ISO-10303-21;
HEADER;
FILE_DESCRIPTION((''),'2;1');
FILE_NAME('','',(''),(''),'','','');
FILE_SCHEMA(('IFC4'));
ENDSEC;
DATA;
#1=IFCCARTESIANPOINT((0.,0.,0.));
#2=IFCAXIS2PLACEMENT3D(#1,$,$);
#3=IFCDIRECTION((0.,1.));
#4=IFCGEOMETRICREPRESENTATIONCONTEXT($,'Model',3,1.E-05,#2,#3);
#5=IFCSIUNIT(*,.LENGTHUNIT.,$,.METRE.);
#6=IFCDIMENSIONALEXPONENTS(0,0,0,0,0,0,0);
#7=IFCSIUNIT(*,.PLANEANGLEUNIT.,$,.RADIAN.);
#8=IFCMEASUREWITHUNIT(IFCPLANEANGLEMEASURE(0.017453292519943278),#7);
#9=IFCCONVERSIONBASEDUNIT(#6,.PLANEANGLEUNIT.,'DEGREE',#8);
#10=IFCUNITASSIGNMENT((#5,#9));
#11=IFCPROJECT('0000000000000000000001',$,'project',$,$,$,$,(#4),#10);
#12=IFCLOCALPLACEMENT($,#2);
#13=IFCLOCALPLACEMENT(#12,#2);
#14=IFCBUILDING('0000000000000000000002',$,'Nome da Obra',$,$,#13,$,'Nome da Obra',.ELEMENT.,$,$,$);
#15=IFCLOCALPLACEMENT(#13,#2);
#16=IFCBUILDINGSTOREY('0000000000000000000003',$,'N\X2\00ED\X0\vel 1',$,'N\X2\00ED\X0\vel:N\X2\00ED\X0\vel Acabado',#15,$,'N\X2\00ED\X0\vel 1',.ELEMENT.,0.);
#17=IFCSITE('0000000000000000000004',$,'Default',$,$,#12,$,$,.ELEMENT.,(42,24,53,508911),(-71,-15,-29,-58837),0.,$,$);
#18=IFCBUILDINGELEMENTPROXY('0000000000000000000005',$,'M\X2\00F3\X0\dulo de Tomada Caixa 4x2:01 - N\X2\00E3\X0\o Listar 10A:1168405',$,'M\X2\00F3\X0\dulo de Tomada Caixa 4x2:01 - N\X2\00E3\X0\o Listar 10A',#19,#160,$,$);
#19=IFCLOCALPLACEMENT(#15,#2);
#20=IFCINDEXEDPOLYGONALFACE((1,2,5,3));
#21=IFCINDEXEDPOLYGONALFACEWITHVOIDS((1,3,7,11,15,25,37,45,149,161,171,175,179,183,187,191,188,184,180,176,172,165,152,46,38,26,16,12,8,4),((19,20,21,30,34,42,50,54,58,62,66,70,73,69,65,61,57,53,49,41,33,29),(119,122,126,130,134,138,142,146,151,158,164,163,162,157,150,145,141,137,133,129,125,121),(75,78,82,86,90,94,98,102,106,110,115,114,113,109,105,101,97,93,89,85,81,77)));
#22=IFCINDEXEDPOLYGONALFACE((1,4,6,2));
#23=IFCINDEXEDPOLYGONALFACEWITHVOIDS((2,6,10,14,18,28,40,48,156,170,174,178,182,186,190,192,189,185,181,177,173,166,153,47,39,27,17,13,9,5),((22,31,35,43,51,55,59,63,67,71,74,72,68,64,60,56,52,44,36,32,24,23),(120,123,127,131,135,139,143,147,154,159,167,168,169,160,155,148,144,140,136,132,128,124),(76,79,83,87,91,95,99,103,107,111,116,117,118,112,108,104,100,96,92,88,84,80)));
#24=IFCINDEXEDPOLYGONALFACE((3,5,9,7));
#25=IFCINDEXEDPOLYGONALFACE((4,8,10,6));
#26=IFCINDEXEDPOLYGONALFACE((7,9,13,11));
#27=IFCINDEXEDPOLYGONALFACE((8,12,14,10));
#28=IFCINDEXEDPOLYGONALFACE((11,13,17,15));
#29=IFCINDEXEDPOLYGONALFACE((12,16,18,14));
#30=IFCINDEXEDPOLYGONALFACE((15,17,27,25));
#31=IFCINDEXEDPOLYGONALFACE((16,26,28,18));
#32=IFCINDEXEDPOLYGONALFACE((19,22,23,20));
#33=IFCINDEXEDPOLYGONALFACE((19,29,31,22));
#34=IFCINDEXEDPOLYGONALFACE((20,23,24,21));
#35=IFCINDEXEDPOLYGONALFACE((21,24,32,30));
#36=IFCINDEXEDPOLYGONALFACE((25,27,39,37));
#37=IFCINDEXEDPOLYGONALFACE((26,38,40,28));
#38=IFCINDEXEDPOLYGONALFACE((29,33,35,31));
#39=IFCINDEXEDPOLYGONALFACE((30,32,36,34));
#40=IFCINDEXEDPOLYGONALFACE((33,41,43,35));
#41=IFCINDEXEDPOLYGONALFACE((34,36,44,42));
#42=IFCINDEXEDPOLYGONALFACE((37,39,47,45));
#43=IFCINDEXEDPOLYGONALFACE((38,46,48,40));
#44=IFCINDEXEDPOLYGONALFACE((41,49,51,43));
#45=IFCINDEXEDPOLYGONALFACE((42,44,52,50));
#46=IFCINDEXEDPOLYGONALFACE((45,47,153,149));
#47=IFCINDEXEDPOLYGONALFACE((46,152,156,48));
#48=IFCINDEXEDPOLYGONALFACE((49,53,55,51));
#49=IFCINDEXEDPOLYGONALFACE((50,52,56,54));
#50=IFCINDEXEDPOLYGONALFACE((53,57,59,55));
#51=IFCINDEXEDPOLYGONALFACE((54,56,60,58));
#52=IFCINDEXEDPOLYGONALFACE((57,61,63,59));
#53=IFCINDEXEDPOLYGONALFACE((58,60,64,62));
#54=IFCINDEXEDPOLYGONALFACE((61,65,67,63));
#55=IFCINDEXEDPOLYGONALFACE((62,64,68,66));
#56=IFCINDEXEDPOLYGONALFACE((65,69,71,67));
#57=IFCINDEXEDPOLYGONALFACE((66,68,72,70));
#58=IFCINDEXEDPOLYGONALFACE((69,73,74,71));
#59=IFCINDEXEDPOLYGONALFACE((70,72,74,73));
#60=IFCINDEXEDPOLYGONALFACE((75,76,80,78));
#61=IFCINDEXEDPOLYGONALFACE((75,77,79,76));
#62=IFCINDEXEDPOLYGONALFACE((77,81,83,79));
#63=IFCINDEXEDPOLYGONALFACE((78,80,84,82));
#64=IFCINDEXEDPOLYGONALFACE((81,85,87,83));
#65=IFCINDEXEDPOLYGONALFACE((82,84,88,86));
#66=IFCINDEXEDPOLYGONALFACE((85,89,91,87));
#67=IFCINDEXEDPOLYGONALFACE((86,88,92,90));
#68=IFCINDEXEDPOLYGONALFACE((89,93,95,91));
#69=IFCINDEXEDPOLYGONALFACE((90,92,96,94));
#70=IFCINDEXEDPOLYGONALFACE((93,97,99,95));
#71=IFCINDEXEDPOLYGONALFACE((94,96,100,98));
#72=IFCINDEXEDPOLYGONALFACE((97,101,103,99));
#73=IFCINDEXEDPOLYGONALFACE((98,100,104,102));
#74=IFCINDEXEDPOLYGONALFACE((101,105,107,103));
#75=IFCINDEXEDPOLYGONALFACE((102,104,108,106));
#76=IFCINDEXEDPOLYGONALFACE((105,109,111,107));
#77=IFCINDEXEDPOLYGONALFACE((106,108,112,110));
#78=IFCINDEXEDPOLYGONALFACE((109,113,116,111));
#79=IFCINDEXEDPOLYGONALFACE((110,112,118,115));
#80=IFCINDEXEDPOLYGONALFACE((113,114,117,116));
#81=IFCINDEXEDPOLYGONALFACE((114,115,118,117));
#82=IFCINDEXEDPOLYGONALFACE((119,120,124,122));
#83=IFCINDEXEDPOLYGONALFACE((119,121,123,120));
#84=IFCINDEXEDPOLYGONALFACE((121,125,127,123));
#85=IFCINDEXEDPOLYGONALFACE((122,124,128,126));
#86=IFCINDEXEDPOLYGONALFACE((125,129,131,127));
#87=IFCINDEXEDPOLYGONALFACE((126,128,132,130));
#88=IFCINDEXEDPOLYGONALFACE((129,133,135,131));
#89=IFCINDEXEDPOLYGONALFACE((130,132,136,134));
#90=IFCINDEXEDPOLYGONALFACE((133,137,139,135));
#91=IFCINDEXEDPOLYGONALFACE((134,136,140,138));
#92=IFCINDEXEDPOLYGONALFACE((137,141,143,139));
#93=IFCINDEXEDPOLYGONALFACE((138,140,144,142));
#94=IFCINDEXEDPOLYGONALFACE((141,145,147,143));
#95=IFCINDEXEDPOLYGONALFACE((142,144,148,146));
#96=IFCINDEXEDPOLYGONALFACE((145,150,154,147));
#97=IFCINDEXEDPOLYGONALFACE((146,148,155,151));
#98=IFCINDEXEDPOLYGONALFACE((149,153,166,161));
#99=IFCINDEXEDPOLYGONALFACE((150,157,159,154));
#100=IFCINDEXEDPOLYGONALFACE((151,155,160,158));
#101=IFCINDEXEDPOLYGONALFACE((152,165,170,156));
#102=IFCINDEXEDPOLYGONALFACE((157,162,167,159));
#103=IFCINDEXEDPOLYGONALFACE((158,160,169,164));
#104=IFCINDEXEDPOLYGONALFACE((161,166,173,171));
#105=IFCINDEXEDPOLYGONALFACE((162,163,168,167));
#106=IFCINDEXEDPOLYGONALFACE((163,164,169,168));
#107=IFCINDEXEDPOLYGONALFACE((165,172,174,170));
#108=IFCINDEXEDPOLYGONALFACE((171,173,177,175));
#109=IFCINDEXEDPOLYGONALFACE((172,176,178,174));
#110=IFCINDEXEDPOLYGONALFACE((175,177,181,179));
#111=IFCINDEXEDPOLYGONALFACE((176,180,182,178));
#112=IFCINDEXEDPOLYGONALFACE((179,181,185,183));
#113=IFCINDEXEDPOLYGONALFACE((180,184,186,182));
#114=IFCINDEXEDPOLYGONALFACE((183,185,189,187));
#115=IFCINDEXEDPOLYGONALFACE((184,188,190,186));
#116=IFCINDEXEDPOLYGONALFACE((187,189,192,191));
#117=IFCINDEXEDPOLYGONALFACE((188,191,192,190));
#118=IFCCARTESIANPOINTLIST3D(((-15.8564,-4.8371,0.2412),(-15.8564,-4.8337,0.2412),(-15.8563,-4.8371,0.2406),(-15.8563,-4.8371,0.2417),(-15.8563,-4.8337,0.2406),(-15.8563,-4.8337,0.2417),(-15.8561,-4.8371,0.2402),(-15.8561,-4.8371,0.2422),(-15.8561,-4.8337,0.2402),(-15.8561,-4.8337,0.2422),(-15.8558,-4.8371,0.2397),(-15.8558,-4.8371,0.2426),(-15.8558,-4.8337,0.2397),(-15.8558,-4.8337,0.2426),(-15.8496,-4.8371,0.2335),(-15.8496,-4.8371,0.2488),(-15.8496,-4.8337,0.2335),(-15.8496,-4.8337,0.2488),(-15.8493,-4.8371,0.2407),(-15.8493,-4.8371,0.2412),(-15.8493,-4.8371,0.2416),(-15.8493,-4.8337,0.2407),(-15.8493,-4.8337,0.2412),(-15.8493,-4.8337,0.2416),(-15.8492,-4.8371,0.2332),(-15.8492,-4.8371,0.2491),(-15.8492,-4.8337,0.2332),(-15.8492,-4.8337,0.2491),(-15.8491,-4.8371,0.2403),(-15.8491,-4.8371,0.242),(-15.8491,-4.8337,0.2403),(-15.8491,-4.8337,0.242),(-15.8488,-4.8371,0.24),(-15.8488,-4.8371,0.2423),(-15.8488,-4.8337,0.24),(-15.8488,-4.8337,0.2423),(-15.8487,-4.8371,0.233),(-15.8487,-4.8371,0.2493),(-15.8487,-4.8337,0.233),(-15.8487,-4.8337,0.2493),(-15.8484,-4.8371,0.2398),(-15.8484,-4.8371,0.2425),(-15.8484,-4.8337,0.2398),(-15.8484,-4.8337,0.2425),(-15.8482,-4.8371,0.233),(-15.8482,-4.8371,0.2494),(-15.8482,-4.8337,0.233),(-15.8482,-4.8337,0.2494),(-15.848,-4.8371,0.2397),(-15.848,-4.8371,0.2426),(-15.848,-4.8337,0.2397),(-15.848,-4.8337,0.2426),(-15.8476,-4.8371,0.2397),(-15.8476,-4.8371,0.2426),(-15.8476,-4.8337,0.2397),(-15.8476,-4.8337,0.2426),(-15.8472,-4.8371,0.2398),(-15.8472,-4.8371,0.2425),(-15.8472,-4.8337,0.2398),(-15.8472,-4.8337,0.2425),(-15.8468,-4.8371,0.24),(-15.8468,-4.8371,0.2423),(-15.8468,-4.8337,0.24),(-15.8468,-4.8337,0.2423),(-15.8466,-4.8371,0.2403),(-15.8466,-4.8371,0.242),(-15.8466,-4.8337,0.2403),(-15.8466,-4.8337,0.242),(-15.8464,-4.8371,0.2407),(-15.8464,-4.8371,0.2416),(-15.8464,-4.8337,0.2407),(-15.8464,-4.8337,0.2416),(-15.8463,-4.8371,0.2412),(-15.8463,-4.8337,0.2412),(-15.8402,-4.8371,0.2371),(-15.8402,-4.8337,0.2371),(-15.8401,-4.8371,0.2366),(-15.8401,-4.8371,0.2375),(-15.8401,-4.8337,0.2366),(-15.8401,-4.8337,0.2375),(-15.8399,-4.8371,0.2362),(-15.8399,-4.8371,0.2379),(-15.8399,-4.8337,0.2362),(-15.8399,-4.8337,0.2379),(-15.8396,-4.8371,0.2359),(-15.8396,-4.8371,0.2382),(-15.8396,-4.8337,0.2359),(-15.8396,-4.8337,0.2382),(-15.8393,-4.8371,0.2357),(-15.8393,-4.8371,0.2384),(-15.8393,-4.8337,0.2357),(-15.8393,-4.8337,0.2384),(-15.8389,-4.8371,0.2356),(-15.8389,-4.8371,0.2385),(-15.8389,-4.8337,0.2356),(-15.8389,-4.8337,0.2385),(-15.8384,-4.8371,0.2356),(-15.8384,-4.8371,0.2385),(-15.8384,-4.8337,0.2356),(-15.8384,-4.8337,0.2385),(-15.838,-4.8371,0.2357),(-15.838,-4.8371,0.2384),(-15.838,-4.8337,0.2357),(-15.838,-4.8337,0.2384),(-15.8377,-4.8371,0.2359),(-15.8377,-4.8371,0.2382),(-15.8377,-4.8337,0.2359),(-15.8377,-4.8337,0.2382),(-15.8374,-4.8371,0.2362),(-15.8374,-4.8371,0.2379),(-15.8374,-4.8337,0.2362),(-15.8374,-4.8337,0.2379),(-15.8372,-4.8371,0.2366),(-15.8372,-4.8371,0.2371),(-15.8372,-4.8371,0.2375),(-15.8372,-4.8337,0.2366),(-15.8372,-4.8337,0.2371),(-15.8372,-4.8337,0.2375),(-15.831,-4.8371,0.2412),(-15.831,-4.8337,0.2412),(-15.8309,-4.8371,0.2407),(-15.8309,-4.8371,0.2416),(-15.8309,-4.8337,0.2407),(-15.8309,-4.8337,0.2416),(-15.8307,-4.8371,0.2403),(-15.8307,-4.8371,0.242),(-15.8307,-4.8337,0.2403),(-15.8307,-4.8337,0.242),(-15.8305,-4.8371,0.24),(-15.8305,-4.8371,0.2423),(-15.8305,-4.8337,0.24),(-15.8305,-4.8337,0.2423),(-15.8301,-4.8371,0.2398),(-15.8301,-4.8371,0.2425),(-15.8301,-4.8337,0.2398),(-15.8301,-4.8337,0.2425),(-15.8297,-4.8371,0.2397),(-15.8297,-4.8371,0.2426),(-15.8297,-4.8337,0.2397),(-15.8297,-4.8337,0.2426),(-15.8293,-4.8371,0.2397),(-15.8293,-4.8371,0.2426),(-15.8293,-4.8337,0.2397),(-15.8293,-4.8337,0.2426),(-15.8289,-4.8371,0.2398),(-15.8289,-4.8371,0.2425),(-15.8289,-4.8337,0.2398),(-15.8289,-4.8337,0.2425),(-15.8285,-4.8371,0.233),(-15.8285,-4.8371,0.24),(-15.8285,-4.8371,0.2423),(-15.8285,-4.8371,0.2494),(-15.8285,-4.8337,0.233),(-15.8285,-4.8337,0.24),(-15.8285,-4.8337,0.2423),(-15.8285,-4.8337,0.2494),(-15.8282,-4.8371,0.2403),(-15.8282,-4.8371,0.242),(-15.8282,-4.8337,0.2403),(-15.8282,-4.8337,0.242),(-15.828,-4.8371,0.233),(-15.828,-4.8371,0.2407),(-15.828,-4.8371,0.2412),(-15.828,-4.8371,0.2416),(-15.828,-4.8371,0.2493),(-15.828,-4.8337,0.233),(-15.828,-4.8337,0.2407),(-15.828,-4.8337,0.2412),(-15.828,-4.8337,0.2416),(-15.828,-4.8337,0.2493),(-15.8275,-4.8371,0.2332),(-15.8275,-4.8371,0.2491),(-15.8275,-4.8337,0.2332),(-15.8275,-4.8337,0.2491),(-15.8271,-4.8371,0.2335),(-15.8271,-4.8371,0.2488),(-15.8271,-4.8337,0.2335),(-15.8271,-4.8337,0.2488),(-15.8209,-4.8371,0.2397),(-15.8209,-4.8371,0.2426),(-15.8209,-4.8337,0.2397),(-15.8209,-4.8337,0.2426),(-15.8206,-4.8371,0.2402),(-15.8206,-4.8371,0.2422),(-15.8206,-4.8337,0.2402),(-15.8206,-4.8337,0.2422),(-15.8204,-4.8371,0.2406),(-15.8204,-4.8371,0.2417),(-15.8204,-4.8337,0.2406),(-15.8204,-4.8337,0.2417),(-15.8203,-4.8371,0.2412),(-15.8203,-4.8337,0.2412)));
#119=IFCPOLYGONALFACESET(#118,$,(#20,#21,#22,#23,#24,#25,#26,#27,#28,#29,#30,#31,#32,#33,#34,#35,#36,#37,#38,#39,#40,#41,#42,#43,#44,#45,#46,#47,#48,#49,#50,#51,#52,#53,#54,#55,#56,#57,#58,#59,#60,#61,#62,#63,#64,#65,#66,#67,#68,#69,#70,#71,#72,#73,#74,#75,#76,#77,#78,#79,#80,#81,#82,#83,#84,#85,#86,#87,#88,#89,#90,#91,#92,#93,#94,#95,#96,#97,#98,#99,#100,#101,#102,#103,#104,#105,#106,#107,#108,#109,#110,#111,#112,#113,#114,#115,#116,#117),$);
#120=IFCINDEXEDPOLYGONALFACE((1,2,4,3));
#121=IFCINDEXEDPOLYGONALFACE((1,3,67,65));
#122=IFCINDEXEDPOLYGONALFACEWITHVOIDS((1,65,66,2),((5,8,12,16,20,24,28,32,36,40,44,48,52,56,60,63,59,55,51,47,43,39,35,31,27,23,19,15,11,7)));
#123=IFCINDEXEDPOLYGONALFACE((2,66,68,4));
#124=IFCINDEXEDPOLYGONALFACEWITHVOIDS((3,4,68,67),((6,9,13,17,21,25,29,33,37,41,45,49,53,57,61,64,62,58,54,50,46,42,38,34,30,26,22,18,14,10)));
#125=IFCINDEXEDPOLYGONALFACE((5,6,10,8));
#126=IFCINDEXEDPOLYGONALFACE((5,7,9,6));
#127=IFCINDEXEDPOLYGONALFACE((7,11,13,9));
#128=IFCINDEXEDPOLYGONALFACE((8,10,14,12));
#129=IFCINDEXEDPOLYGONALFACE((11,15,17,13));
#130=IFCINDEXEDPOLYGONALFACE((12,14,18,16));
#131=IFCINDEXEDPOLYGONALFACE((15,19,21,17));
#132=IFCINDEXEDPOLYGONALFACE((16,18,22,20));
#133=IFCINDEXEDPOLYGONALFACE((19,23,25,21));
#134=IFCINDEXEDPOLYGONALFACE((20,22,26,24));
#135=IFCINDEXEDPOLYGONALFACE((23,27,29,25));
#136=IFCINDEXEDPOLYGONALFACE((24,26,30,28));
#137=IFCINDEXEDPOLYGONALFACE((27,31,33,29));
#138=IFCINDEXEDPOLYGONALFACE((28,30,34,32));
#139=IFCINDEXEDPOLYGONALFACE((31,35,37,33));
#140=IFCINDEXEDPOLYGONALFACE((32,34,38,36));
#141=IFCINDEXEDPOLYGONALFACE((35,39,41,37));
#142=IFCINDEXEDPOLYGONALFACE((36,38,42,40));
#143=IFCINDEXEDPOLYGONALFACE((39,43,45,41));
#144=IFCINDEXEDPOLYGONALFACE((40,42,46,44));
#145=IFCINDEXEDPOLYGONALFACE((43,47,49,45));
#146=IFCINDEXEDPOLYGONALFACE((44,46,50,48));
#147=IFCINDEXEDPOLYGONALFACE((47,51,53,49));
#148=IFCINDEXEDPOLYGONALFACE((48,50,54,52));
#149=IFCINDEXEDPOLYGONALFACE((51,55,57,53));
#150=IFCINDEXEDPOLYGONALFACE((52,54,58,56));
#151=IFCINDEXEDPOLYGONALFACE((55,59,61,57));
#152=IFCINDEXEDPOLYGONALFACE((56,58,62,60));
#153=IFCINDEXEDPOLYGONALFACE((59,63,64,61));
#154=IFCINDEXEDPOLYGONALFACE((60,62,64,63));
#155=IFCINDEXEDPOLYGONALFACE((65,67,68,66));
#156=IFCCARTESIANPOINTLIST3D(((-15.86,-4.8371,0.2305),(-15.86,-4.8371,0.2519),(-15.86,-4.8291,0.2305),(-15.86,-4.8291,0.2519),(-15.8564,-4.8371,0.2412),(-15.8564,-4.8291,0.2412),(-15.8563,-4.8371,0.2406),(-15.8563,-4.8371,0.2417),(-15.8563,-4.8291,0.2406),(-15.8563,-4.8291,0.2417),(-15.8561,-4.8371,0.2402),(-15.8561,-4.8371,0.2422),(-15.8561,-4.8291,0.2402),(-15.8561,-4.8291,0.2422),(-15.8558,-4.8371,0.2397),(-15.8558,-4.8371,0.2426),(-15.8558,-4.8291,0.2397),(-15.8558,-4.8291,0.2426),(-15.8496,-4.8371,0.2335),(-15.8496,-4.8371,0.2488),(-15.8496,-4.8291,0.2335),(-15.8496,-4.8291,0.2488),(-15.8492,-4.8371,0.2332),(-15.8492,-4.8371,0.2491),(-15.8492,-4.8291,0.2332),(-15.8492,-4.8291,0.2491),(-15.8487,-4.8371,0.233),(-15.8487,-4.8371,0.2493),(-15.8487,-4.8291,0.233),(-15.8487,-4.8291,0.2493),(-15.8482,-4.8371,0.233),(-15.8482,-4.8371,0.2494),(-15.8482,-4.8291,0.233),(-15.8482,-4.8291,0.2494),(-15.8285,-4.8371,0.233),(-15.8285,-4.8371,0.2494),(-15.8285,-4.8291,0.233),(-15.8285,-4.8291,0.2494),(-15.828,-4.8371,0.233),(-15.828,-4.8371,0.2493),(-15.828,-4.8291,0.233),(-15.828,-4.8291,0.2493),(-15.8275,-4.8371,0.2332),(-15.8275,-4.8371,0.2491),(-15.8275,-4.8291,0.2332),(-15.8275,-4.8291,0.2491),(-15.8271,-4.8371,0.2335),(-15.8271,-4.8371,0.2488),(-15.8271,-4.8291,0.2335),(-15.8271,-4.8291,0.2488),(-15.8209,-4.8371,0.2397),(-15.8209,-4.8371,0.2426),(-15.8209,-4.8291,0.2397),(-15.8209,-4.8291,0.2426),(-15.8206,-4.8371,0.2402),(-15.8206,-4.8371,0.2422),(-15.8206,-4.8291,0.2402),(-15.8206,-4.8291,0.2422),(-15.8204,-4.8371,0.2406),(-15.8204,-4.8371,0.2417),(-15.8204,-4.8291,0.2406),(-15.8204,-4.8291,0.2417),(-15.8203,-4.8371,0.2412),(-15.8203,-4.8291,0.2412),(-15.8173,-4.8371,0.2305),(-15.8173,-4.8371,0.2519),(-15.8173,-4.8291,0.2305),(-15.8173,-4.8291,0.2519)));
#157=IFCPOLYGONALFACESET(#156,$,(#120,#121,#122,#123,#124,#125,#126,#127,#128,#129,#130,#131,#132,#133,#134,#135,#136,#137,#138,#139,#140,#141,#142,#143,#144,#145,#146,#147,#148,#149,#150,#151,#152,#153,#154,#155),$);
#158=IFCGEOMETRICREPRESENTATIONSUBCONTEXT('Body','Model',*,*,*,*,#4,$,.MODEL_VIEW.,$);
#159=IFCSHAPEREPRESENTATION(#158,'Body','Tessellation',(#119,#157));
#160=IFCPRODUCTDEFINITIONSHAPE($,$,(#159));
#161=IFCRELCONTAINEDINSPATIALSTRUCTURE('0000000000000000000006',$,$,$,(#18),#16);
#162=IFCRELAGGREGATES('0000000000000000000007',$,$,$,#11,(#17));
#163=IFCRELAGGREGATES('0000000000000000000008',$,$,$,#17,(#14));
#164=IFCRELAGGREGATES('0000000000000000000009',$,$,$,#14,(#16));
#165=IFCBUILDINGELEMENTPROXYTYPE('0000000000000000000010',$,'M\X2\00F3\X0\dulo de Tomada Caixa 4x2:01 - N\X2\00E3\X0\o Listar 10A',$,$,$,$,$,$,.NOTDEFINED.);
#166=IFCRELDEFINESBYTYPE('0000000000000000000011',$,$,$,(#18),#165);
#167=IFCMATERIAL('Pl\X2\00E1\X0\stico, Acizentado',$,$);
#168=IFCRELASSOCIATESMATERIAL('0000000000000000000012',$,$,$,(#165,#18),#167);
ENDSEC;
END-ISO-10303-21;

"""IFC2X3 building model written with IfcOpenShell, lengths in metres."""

from ifc_helpers import new_model, entity, si_unit, converted_unit, direction, frame, frame_2d, origin, place, context, subcontext, project, spatial, polyline, circle_curve, parameter, trimmed, segment, composite_curve, outline, extrude, source, transform, mapped, material, type_object, type_shapes, element, save


model = new_model("IFC2X3")

# Units and contexts
model_context = context("Model", 3, precision=1e-05, world=origin(), true_north=direction((0.0, 1.0)))
body_context = subcontext(model_context, "Body", "Model", "MODEL_VIEW")
ifc_project = project(units=[si_unit("LENGTHUNIT", "METRE"), converted_unit("PLANEANGLEUNIT", "DEGREE", entity("IfcPlaneAngleMeasure", 0.017453292519943278), si_unit("PLANEANGLEUNIT", "RADIAN"), dimensions=[0, 0, 0, 0, 0, 0, 0])], contexts=[model_context])

# Site, building, storey
site_placement = place(None, origin())
site = spatial("IfcSite", under=ifc_project, at=site_placement, Name="Default", CompositionType="ELEMENT", RefLatitude=(42, 24, 53, 508911), RefLongitude=(-71, -15, -29, -58837), RefElevation=0.0)
building_placement = place(site_placement, origin())
building = spatial("IfcBuilding", under=site, at=building_placement, Name="Nome da Obra", LongName="Nome da Obra", CompositionType="ELEMENT")
storey_placement = place(building_placement, origin())
storey = spatial("IfcBuildingStorey", under=building, at=storey_placement, Name="Nível 1", ObjectType="Nível:Nível Acabado", LongName="Nível 1", CompositionType="ELEMENT", Elevation=0.0)

# Building element proxy
ifc_material_1 = material(Name="Plástico, Acizentado")
building_element_proxy_type_1 = type_object("IfcBuildingElementProxyType", Name="Módulo de Tomada Caixa 4x2:01 - Não Listar 10A", PredefinedType="NOTDEFINED", material=ifc_material_1)
shared_shape_1 = source(origin(), body_context, "Body", "SweptSolid", [
    extrude(outline(composite_curve([segment(polyline([(-0.0098, -0.0082), (0.0098, -0.0082)]), True, "CONTINUOUS"), segment(trimmed(circle_curve(frame_2d((0.0098, -0.0062), x_axis=(1.0, 0.0)), 0.002), [parameter(270.0)], [parameter(315.0)], True, "PARAMETER"), True, "CONTINUOUS"), segment(polyline([(0.0112, -0.0076), (0.0174, -0.0014)]), True, "CONTINUOUS"), segment(trimmed(circle_curve(frame_2d((0.016, 0.0), x_axis=(1.0, 0.0)), 0.002), [parameter(315.0)], [parameter(45.0)], True, "PARAMETER"), True, "CONTINUOUS"), segment(polyline([(0.0174, 0.0014), (0.0112, 0.0076)]), True, "CONTINUOUS"), segment(trimmed(circle_curve(frame_2d((0.0098, 0.0062), x_axis=(1.0, 0.0)), 0.002), [parameter(45.0)], [parameter(90.0)], True, "PARAMETER"), True, "CONTINUOUS"), segment(polyline([(0.0098, 0.0082), (-0.0098, 0.0082)]), True, "CONTINUOUS"), segment(trimmed(circle_curve(frame_2d((-0.0098, 0.0062), x_axis=(1.0, 0.0)), 0.002), [parameter(90.0)], [parameter(135.0)], True, "PARAMETER"), True, "CONTINUOUS"), segment(polyline([(-0.0112, 0.0076), (-0.0174, 0.0014)]), True, "CONTINUOUS"), segment(trimmed(circle_curve(frame_2d((-0.016, 0.0), x_axis=(1.0, 0.0)), 0.002), [parameter(135.0)], [parameter(225.0)], True, "PARAMETER"), True, "CONTINUOUS"), segment(polyline([(-0.0174, -0.0014), (-0.0112, -0.0076)]), True, "CONTINUOUS"), segment(trimmed(circle_curve(frame_2d((-0.0098, -0.0062), x_axis=(1.0, 0.0)), 0.002), [parameter(225.0)], [parameter(270.0)], True, "PARAMETER"), True, "CONTINUOUS")], self_intersect=False), holes=[composite_curve([segment(trimmed(circle_curve(frame_2d((0.0089, 0.0), x_axis=(1.0, 0.0)), 0.0015), [parameter(0.0)], [parameter(180.0)], True, "PARAMETER"), False, "CONTINUOUS"), segment(trimmed(circle_curve(frame_2d((0.0089, 0.0), x_axis=(1.0, 0.0)), 0.0015), [parameter(180.0)], [parameter(0.0)], True, "PARAMETER"), False, "CONTINUOUS")], self_intersect=False), composite_curve([segment(trimmed(circle_curve(frame_2d((-0.0003, 0.0041), x_axis=(1.0, 0.0)), 0.0015), [parameter(0.0)], [parameter(180.0)], True, "PARAMETER"), False, "CONTINUOUS"), segment(trimmed(circle_curve(frame_2d((-0.0003, 0.0041), x_axis=(1.0, 0.0)), 0.0015), [parameter(180.0)], [parameter(0.0)], True, "PARAMETER"), False, "CONTINUOUS")], self_intersect=False), composite_curve([segment(trimmed(circle_curve(frame_2d((-0.0095, 0.0), x_axis=(1.0, 0.0)), 0.0015), [parameter(0.0)], [parameter(180.0)], True, "PARAMETER"), False, "CONTINUOUS"), segment(trimmed(circle_curve(frame_2d((-0.0095, 0.0), x_axis=(1.0, 0.0)), 0.0015), [parameter(180.0)], [parameter(0.0)], True, "PARAMETER"), False, "CONTINUOUS")], self_intersect=False)]), frame((0.0003, 0.0, 0.125), z_axis=(0.0, 1.0, 0.0), x_axis=(1.0, 0.0, 0.0)), (0.0, 0.0, 1.0), 0.0034),
    extrude(outline(polyline([(-0.0214, -0.0107), (0.0214, -0.0107), (0.0214, 0.0107), (-0.0214, 0.0107), (-0.0214, -0.0107)]), holes=[composite_curve([segment(polyline([(0.0101, -0.0082), (-0.0095, -0.0082)]), True, "CONTINUOUS"), segment(trimmed(circle_curve(frame_2d((-0.0095, -0.0062), x_axis=(1.0, 0.0)), 0.002), [parameter(225.0)], [parameter(270.0)], True, "PARAMETER"), False, "CONTINUOUS"), segment(polyline([(-0.0109, -0.0076), (-0.0171, -0.0014)]), True, "CONTINUOUS"), segment(trimmed(circle_curve(frame_2d((-0.0157, 0.0), x_axis=(1.0, 0.0)), 0.002), [parameter(135.0)], [parameter(225.0)], True, "PARAMETER"), False, "CONTINUOUS"), segment(polyline([(-0.0171, 0.0014), (-0.0109, 0.0076)]), True, "CONTINUOUS"), segment(trimmed(circle_curve(frame_2d((-0.0095, 0.0062), x_axis=(1.0, 0.0)), 0.002), [parameter(90.0)], [parameter(135.0)], True, "PARAMETER"), False, "CONTINUOUS"), segment(polyline([(-0.0095, 0.0082), (0.0101, 0.0082)]), True, "CONTINUOUS"), segment(trimmed(circle_curve(frame_2d((0.0101, 0.0062), x_axis=(1.0, 0.0)), 0.002), [parameter(45.0)], [parameter(90.0)], True, "PARAMETER"), False, "CONTINUOUS"), segment(polyline([(0.0115, 0.0076), (0.0177, 0.0014)]), True, "CONTINUOUS"), segment(trimmed(circle_curve(frame_2d((0.0163, 0.0), x_axis=(1.0, 0.0)), 0.002), [parameter(315.0)], [parameter(45.0)], True, "PARAMETER"), False, "CONTINUOUS"), segment(polyline([(0.0177, -0.0014), (0.0115, -0.0076)]), True, "CONTINUOUS"), segment(trimmed(circle_curve(frame_2d((0.0101, -0.0062), x_axis=(1.0, 0.0)), 0.002), [parameter(270.0)], [parameter(315.0)], True, "PARAMETER"), False, "CONTINUOUS")], self_intersect=False)]), frame((0.0, 0.0, 0.125), z_axis=(0.0, 1.0, 0.0), x_axis=(1.0, 0.0, 0.0)), (0.0, 0.0, 1.0), 0.008),
])
type_shapes(building_element_proxy_type_1, [shared_shape_1])
for number, where, name in (
    (1, (-15.8387, -4.8371, 0.1162), "Módulo de Tomada Caixa 4x2:01 - Não Listar 10A:1168405"),
):
    element("IfcBuildingElementProxy", number, at=place(storey_placement, frame(where)), inside=storey, type_object=building_element_proxy_type_1, material=ifc_material_1, Name=name, ObjectType="Módulo de Tomada Caixa 4x2:01 - Não Listar 10A", context=body_context, shape_type="MappedRepresentation", body=[
        mapped(shared_shape_1, transform((0.0, 0.0, 0.0), scale=1.0)),
    ])

save(model, "model.ifc")
